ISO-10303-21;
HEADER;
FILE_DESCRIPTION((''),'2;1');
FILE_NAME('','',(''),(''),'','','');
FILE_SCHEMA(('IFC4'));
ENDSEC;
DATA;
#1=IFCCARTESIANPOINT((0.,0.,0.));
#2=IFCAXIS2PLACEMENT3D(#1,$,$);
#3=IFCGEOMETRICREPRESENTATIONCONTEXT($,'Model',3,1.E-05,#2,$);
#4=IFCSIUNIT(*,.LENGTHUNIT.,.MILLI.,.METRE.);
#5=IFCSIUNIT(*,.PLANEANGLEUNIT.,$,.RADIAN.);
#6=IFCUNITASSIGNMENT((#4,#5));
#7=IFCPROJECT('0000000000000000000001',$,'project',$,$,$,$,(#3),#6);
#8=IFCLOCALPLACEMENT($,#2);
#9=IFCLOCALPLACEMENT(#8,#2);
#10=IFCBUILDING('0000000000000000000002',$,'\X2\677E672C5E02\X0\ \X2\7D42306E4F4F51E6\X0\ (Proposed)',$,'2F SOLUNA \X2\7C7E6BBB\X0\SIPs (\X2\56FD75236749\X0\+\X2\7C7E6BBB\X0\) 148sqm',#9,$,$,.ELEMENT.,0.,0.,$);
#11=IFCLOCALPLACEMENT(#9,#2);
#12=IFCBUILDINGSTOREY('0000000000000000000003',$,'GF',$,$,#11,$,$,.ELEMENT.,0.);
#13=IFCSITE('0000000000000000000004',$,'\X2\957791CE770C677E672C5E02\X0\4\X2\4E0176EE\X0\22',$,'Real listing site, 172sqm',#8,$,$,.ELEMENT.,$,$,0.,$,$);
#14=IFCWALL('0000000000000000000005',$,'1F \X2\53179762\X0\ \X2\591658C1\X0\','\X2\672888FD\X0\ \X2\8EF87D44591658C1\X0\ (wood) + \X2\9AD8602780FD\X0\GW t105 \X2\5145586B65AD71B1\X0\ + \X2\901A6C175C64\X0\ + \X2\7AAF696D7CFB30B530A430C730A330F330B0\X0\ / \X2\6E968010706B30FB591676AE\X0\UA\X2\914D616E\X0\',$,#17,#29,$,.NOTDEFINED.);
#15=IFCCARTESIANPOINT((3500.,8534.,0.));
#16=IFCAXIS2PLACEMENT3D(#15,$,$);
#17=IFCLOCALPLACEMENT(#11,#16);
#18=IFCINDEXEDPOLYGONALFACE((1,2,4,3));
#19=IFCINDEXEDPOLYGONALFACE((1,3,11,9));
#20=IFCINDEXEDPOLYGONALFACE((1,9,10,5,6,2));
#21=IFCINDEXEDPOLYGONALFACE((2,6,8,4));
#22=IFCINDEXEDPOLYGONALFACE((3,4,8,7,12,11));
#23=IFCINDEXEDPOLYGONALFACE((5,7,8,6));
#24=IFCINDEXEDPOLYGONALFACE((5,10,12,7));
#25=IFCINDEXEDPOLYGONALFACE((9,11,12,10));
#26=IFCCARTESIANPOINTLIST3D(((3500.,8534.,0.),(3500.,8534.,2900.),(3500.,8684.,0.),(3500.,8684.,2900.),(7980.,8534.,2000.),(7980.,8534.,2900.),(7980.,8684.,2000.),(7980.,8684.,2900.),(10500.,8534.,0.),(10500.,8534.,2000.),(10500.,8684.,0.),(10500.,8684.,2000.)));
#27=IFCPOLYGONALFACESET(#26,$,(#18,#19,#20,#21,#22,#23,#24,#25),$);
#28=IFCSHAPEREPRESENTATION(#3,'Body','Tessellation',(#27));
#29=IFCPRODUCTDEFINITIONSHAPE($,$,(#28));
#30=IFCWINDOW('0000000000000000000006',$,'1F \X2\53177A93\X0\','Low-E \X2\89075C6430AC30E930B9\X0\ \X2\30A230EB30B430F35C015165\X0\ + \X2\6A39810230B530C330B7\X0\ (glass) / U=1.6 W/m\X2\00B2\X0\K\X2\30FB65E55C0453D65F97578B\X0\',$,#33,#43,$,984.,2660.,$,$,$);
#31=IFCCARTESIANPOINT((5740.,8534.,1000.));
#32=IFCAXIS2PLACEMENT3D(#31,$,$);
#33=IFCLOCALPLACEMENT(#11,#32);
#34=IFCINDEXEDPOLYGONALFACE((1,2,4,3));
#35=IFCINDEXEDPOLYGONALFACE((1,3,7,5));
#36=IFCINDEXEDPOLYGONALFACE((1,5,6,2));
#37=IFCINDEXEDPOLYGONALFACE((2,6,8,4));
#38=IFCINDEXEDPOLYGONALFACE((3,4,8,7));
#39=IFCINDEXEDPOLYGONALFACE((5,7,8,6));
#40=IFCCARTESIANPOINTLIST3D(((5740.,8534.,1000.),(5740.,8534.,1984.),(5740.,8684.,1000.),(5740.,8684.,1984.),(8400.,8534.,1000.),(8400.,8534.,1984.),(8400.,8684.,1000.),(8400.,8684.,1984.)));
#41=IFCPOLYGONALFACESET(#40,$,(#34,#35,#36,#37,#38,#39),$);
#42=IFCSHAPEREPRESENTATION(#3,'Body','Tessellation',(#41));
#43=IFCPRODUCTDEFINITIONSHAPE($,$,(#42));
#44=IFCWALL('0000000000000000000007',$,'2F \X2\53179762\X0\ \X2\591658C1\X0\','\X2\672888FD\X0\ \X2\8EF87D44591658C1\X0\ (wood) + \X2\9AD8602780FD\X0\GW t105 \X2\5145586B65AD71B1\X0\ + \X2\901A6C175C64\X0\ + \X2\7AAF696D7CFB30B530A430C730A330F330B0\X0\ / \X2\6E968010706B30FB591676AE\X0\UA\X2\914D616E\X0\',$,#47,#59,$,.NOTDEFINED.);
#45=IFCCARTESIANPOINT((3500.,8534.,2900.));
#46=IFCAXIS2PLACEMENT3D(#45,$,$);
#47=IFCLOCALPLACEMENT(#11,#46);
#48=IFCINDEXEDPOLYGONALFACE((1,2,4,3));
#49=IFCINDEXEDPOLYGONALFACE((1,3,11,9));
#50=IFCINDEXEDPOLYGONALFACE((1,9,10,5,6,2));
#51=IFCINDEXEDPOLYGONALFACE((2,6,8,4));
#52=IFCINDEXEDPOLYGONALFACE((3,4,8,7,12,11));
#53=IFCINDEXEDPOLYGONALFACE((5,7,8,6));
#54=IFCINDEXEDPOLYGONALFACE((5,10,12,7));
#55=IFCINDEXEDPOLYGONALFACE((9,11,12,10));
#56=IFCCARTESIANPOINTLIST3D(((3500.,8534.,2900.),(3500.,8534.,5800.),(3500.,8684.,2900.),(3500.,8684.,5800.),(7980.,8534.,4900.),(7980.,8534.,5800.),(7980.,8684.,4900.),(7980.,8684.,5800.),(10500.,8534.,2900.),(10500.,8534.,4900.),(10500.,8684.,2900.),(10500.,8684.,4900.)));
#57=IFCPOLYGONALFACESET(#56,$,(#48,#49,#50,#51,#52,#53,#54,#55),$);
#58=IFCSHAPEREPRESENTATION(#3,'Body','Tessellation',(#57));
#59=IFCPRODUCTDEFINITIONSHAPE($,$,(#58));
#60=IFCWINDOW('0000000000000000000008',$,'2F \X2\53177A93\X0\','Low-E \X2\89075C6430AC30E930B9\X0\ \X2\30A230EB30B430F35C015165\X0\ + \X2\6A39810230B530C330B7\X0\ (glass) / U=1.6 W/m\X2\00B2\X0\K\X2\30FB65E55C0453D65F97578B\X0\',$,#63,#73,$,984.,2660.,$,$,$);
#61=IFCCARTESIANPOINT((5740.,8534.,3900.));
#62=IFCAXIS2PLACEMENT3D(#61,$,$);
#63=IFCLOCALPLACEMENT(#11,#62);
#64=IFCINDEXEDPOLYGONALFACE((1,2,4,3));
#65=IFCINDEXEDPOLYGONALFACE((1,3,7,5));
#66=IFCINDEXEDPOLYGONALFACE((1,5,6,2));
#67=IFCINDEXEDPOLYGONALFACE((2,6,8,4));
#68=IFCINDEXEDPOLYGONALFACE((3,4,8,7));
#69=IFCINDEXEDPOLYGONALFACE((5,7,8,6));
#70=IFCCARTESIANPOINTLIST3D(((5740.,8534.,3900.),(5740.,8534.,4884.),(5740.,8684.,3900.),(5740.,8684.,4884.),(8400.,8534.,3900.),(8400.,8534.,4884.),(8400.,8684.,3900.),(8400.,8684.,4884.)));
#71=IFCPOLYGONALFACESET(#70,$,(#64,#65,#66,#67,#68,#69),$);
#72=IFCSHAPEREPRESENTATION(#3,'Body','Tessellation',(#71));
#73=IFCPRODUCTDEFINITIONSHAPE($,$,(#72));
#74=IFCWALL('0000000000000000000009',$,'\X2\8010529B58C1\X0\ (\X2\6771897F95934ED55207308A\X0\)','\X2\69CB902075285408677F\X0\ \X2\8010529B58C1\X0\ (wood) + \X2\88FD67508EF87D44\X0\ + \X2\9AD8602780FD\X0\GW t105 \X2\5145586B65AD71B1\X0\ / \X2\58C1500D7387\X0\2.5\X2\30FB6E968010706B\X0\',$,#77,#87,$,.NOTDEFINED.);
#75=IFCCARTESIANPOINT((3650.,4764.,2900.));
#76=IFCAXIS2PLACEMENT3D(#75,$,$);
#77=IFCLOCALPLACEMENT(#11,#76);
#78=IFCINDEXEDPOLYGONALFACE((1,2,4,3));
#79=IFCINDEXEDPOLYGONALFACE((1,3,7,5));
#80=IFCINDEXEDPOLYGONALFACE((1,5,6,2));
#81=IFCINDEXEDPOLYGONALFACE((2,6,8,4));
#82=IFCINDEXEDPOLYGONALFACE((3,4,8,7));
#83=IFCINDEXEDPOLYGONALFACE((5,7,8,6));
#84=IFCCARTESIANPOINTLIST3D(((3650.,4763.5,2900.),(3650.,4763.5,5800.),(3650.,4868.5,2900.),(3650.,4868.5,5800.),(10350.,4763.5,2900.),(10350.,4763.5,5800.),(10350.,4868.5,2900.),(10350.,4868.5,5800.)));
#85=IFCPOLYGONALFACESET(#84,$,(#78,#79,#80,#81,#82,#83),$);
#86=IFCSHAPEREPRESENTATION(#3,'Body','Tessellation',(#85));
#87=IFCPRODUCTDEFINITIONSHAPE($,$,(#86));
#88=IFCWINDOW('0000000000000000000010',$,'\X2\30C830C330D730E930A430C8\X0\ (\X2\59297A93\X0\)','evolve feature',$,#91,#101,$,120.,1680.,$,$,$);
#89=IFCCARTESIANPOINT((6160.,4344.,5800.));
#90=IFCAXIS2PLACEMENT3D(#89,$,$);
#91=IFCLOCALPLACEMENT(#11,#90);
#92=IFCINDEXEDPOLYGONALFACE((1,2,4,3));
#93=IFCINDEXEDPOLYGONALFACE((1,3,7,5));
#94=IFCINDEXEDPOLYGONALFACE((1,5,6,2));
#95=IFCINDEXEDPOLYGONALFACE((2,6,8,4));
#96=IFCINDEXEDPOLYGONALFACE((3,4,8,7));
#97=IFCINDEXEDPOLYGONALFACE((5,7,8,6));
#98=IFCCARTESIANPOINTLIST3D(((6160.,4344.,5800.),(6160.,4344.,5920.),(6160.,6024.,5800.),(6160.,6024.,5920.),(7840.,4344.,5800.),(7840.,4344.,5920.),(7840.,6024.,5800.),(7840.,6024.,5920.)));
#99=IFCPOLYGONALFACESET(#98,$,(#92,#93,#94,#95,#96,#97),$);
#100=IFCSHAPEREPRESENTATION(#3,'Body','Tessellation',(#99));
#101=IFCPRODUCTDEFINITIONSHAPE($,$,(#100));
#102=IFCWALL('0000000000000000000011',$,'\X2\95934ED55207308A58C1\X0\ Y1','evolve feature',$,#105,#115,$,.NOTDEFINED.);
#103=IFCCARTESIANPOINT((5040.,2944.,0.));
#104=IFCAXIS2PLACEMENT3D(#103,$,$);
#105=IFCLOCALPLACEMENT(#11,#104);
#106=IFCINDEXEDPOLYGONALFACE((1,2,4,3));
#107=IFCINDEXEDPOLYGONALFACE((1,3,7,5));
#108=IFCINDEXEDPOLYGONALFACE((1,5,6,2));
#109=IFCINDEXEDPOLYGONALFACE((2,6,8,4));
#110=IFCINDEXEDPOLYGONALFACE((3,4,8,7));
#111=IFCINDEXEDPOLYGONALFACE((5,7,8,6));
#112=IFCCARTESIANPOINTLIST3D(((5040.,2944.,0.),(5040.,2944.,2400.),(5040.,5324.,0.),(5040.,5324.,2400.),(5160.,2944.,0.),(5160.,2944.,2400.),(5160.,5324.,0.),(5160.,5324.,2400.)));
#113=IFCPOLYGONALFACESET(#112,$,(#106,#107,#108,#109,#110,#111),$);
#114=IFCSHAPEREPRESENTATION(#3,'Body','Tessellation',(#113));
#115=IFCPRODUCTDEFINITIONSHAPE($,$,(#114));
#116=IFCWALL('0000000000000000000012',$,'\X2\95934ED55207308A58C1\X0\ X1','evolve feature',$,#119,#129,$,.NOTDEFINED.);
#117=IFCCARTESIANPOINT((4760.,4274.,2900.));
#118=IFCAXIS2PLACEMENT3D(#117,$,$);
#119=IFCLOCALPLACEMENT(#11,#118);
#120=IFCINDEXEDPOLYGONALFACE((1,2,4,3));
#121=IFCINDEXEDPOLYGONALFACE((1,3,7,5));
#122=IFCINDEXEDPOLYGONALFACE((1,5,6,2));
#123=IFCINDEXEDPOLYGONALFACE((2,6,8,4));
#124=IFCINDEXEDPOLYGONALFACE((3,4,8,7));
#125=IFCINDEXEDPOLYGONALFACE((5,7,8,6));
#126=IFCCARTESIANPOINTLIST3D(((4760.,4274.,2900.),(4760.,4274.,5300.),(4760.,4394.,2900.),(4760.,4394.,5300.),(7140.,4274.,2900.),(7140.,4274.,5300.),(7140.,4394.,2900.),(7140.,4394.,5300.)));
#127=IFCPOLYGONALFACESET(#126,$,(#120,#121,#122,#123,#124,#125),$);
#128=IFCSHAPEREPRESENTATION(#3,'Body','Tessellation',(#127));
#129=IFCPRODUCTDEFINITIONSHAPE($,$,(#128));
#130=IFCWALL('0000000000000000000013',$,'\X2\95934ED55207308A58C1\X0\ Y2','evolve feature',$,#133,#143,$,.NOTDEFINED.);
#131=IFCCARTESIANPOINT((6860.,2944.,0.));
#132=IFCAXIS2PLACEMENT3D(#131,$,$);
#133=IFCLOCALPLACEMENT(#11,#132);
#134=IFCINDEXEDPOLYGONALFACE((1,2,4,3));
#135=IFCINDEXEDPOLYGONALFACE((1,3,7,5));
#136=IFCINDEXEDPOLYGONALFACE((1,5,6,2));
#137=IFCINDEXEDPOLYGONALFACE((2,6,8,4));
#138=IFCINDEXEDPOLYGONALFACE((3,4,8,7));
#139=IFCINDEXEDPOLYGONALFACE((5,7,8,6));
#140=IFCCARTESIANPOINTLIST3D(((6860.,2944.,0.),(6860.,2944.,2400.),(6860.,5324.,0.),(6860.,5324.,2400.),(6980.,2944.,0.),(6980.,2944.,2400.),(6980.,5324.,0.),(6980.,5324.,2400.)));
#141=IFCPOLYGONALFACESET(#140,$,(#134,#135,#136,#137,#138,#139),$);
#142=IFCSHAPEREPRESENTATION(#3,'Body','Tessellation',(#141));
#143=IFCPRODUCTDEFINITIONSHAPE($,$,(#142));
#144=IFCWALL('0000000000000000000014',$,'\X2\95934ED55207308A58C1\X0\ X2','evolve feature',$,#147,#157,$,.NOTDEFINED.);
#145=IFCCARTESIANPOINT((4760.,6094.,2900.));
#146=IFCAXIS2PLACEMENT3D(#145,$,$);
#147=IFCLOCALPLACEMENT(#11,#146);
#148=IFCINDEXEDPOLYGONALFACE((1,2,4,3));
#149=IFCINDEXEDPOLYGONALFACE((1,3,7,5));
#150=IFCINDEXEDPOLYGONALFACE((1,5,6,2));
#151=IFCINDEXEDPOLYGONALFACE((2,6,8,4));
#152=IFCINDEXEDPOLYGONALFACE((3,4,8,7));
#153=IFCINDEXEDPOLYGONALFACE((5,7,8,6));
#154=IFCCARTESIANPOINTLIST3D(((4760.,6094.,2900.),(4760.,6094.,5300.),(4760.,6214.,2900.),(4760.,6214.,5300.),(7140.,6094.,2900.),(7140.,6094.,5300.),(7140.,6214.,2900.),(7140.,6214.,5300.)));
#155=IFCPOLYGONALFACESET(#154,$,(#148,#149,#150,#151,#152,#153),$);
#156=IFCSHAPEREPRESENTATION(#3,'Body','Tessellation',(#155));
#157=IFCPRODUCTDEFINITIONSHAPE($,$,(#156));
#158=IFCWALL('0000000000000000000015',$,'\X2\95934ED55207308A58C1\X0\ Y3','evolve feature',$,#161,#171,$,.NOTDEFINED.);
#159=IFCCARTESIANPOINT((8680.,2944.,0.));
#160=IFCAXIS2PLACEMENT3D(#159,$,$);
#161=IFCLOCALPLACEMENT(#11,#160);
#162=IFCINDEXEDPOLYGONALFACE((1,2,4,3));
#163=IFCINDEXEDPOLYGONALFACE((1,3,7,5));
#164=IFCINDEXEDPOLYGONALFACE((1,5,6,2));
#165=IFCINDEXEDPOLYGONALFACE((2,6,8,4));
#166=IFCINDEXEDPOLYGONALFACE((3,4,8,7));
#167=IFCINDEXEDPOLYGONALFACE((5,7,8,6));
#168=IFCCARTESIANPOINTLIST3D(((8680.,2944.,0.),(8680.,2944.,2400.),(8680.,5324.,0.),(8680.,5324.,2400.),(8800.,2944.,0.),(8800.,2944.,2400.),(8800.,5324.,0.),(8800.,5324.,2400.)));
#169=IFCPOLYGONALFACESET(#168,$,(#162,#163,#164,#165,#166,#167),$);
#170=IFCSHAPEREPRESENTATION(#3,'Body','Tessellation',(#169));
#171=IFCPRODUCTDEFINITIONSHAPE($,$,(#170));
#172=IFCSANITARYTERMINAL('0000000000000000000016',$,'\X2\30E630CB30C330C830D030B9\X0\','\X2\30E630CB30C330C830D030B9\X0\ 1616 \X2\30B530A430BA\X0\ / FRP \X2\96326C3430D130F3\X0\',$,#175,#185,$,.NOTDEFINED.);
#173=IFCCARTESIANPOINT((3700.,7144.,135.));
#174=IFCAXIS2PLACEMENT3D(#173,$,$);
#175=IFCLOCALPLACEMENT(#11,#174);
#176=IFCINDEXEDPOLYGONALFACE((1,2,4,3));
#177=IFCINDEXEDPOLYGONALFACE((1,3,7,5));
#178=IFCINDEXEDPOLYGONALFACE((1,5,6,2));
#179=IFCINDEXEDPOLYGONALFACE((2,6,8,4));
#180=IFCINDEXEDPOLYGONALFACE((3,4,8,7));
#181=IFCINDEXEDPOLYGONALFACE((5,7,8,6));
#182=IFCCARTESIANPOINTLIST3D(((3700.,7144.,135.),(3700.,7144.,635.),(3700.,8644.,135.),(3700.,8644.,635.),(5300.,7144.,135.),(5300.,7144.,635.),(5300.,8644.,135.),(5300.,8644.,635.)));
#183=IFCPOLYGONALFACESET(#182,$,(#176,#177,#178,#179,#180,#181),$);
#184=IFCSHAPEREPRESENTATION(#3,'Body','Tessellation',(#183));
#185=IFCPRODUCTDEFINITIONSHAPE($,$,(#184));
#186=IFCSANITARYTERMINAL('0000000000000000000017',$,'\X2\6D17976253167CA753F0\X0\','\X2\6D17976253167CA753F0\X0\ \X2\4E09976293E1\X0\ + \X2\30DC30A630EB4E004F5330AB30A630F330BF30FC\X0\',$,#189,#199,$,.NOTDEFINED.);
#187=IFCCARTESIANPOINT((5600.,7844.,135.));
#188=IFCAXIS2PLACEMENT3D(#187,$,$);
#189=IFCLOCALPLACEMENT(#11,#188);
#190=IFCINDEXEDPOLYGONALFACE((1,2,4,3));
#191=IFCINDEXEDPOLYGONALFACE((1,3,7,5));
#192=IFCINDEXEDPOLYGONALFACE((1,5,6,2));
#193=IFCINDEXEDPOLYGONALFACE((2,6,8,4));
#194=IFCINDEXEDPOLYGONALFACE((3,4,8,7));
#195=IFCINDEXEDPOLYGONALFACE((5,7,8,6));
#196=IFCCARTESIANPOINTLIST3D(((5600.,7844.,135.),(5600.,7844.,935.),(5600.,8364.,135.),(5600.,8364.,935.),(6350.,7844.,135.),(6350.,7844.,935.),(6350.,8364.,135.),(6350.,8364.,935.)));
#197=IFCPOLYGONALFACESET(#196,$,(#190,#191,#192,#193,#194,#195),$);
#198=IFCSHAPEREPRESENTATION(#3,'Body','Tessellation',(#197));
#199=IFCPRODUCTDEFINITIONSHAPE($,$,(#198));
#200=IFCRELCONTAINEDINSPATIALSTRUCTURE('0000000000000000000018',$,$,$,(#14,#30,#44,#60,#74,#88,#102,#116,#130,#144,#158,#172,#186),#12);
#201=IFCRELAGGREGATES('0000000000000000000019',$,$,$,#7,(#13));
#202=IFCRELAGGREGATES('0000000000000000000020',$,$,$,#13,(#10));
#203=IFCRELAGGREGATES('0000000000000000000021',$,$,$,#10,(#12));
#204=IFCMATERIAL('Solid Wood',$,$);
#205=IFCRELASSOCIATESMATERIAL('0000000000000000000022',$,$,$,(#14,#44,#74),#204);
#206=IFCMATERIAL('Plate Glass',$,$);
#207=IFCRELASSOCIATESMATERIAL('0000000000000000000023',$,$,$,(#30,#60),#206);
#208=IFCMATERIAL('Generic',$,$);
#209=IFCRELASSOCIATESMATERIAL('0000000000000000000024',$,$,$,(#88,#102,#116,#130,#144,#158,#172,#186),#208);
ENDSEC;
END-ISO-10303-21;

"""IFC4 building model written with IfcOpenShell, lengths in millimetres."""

from ifc_helpers import new_model, si_unit, frame, frame_2d, origin, place, context, project, spatial, rectangle, extrude, material, element, fill, save


model = new_model("IFC4")

# Units and contexts
model_context = context("Model", 3, precision=1e-05, world=origin())
ifc_project = project(units=[si_unit("LENGTHUNIT", "METRE", prefix="MILLI"), si_unit("PLANEANGLEUNIT", "RADIAN")], contexts=[model_context])

# Site, building, storey
site_placement = place(None, origin())
site = spatial("IfcSite", under=ifc_project, at=site_placement, Name="長野県松本市4丁目22", ObjectType="Real listing site, 172sqm", CompositionType="ELEMENT", RefElevation=0.0)
building_placement = place(site_placement, origin())
building = spatial("IfcBuilding", under=site, at=building_placement, Name="松本市 終の住処 (Proposed)", ObjectType="2F SOLUNA 籾殻SIPs (国産杉+籾殻) 148sqm", CompositionType="ELEMENT", ElevationOfRefHeight=0.0, ElevationOfTerrain=0.0)
storey_placement = place(building_placement, origin())
storey = spatial("IfcBuildingStorey", under=building, at=storey_placement, Name="GF", CompositionType="ELEMENT", Elevation=0.0)

# Wall, opening, window
ifc_material_1 = material(Name="Solid Wood")
wall_1_placement = place(storey_placement, frame((3500.0, 8534.0, 0.0)))
wall_1 = element("IfcWall", 1, at=wall_1_placement, inside=storey, material=ifc_material_1, Name="1F 北面 外壁", Description="木製 軸組外壁 (wood) + 高性能GW t105 充填断熱 + 通気層 + 窯業系サイディング / 準耐火・外皮UA配慮", PredefinedType="NOTDEFINED", context=model_context, shape_type="SweptSolid", body=[
    extrude(rectangle(XDim=7000.0, YDim=150.0, at=frame_2d((3500.0, 75.0))), frame((3500.0, 8534.0, 0.0)), (0.0, 0.0, 1.0), 2900.0),
])
opening_1_placement = place(storey_placement, frame((5740.0, 8534.0, 1000.0)))
opening_1 = element("IfcOpeningElement", 2, at=opening_1_placement, cuts=wall_1, PredefinedType="NOTDEFINED", context=model_context, shape_type="SweptSolid", body=[
    extrude(rectangle(XDim=2660.0, YDim=150.0, at=frame_2d((1330.0, 75.0))), frame((5740.0, 8534.0, 1000.0)), (0.0, 0.0, 1.0), 984.0),
])
ifc_material_2 = material(Name="Plate Glass")
window_1_placement = place(storey_placement, frame((5740.0, 8534.0, 1000.0)))
window_1 = element("IfcWindow", 3, at=window_1_placement, inside=storey, material=ifc_material_2, Name="1F 北窓", Description="Low-E 複層ガラス アルゴン封入 + 樹脂サッシ (glass) / U=1.6 W/m²K・日射取得型", OverallHeight=984.0, OverallWidth=2660.0, context=model_context, shape_type="SweptSolid", body=[
    extrude(rectangle(XDim=2660.0, YDim=150.0, at=frame_2d((1330.0, 75.0))), frame((5740.0, 8534.0, 1000.0)), (0.0, 0.0, 1.0), 984.0),
])
fill(opening_1, window_1)

# Wall, opening, window
wall_2_placement = place(storey_placement, frame((3500.0, 8534.0, 2900.0)))
wall_2 = element("IfcWall", 4, at=wall_2_placement, inside=storey, material=ifc_material_1, Name="2F 北面 外壁", Description="木製 軸組外壁 (wood) + 高性能GW t105 充填断熱 + 通気層 + 窯業系サイディング / 準耐火・外皮UA配慮", PredefinedType="NOTDEFINED", context=model_context, shape_type="SweptSolid", body=[
    extrude(rectangle(XDim=7000.0, YDim=150.0, at=frame_2d((3500.0, 75.0))), frame((3500.0, 8534.0, 2900.0)), (0.0, 0.0, 1.0), 2900.0),
])
opening_2_placement = place(storey_placement, frame((5740.0, 8534.0, 3900.0)))
opening_2 = element("IfcOpeningElement", 5, at=opening_2_placement, cuts=wall_2, PredefinedType="NOTDEFINED", context=model_context, shape_type="SweptSolid", body=[
    extrude(rectangle(XDim=2660.0, YDim=150.0, at=frame_2d((1330.0, 75.0))), frame((5740.0, 8534.0, 3900.0)), (0.0, 0.0, 1.0), 984.0),
])
window_2_placement = place(storey_placement, frame((5740.0, 8534.0, 3900.0)))
window_2 = element("IfcWindow", 6, at=window_2_placement, inside=storey, material=ifc_material_2, Name="2F 北窓", Description="Low-E 複層ガラス アルゴン封入 + 樹脂サッシ (glass) / U=1.6 W/m²K・日射取得型", OverallHeight=984.0, OverallWidth=2660.0, context=model_context, shape_type="SweptSolid", body=[
    extrude(rectangle(XDim=2660.0, YDim=150.0, at=frame_2d((1330.0, 75.0))), frame((5740.0, 8534.0, 3900.0)), (0.0, 0.0, 1.0), 984.0),
])
fill(opening_2, window_2)

# Wall
wall_3_placement = place(storey_placement, frame((3650.0, 4764.0, 2900.0)))
element("IfcWall", 7, at=wall_3_placement, inside=storey, material=ifc_material_1, Name="耐力壁 (東西間仕切り)", Description="構造用合板 耐力壁 (wood) + 製材軸組 + 高性能GW t105 充填断熱 / 壁倍率2.5・準耐火", PredefinedType="NOTDEFINED", context=model_context, shape_type="SweptSolid", body=[
    extrude(rectangle(XDim=6700.0, YDim=105.0, at=frame_2d((3350.0, 52.0))), frame((3650.0, 4764.0, 2900.0)), (0.0, 0.0, 1.0), 2900.0),
])

# Window
ifc_material_3 = material(Name="Generic")
window_3_placement = place(storey_placement, frame((6160.0, 4344.0, 5800.0)))
element("IfcWindow", 8, at=window_3_placement, inside=storey, material=ifc_material_3, Name="トップライト (天窓)", Description="evolve feature", OverallHeight=120.0, OverallWidth=1680.0, context=model_context, shape_type="SweptSolid", body=[
    extrude(rectangle(XDim=1680.0, YDim=1680.0, at=frame_2d((840.0, 840.0))), frame((6160.0, 4344.0, 5800.0)), (0.0, 0.0, 1.0), 120.0),
])

# Walls
wall_4_placement = place(storey_placement, frame((5040.0, 2944.0, 0.0)))
element("IfcWall", 9, at=wall_4_placement, inside=storey, material=ifc_material_3, Name="間仕切り壁 Y1", Description="evolve feature", PredefinedType="NOTDEFINED", context=model_context, shape_type="SweptSolid", body=[
    extrude(rectangle(XDim=120.0, YDim=2380.0, at=frame_2d((60.0, 1190.0))), frame((5040.0, 2944.0, 0.0)), (0.0, 0.0, 1.0), 2400.0),
])
wall_5_placement = place(storey_placement, frame((4760.0, 4274.0, 2900.0)))
element("IfcWall", 10, at=wall_5_placement, inside=storey, material=ifc_material_3, Name="間仕切り壁 X1", Description="evolve feature", PredefinedType="NOTDEFINED", context=model_context, shape_type="SweptSolid", body=[
    extrude(rectangle(XDim=2380.0, YDim=120.0, at=frame_2d((1190.0, 60.0))), frame((4760.0, 4274.0, 2900.0)), (0.0, 0.0, 1.0), 2400.0),
])
wall_6_placement = place(storey_placement, frame((6860.0, 2944.0, 0.0)))
element("IfcWall", 11, at=wall_6_placement, inside=storey, material=ifc_material_3, Name="間仕切り壁 Y2", Description="evolve feature", PredefinedType="NOTDEFINED", context=model_context, shape_type="SweptSolid", body=[
    extrude(rectangle(XDim=120.0, YDim=2380.0, at=frame_2d((60.0, 1190.0))), frame((6860.0, 2944.0, 0.0)), (0.0, 0.0, 1.0), 2400.0),
])
wall_7_placement = place(storey_placement, frame((4760.0, 6094.0, 2900.0)))
element("IfcWall", 12, at=wall_7_placement, inside=storey, material=ifc_material_3, Name="間仕切り壁 X2", Description="evolve feature", PredefinedType="NOTDEFINED", context=model_context, shape_type="SweptSolid", body=[
    extrude(rectangle(XDim=2380.0, YDim=120.0, at=frame_2d((1190.0, 60.0))), frame((4760.0, 6094.0, 2900.0)), (0.0, 0.0, 1.0), 2400.0),
])
wall_8_placement = place(storey_placement, frame((8680.0, 2944.0, 0.0)))
element("IfcWall", 13, at=wall_8_placement, inside=storey, material=ifc_material_3, Name="間仕切り壁 Y3", Description="evolve feature", PredefinedType="NOTDEFINED", context=model_context, shape_type="SweptSolid", body=[
    extrude(rectangle(XDim=120.0, YDim=2380.0, at=frame_2d((60.0, 1190.0))), frame((8680.0, 2944.0, 0.0)), (0.0, 0.0, 1.0), 2400.0),
])

# Sanitary terminals
sanitary_terminal_1_placement = place(storey_placement, frame((3700.0, 7144.0, 135.0)))
element("IfcSanitaryTerminal", 14, at=sanitary_terminal_1_placement, inside=storey, material=ifc_material_3, Name="ユニットバス", Description="ユニットバス 1616 サイズ / FRP 防水パン", PredefinedType="NOTDEFINED", context=model_context, shape_type="SweptSolid", body=[
    extrude(rectangle(XDim=1600.0, YDim=1500.0, at=frame_2d((800.0, 750.0))), frame((3700.0, 7144.0, 135.0)), (0.0, 0.0, 1.0), 500.0),
])
sanitary_terminal_2_placement = place(storey_placement, frame((5600.0, 7844.0, 135.0)))
element("IfcSanitaryTerminal", 15, at=sanitary_terminal_2_placement, inside=storey, material=ifc_material_3, Name="洗面化粧台", Description="洗面化粧台 三面鏡 + ボウル一体カウンター", PredefinedType="NOTDEFINED", context=model_context, shape_type="SweptSolid", body=[
    extrude(rectangle(XDim=750.0, YDim=520.0, at=frame_2d((375.0, 260.0))), frame((5600.0, 7844.0, 135.0)), (0.0, 0.0, 1.0), 800.0),
])

save(model, "model.ifc")
